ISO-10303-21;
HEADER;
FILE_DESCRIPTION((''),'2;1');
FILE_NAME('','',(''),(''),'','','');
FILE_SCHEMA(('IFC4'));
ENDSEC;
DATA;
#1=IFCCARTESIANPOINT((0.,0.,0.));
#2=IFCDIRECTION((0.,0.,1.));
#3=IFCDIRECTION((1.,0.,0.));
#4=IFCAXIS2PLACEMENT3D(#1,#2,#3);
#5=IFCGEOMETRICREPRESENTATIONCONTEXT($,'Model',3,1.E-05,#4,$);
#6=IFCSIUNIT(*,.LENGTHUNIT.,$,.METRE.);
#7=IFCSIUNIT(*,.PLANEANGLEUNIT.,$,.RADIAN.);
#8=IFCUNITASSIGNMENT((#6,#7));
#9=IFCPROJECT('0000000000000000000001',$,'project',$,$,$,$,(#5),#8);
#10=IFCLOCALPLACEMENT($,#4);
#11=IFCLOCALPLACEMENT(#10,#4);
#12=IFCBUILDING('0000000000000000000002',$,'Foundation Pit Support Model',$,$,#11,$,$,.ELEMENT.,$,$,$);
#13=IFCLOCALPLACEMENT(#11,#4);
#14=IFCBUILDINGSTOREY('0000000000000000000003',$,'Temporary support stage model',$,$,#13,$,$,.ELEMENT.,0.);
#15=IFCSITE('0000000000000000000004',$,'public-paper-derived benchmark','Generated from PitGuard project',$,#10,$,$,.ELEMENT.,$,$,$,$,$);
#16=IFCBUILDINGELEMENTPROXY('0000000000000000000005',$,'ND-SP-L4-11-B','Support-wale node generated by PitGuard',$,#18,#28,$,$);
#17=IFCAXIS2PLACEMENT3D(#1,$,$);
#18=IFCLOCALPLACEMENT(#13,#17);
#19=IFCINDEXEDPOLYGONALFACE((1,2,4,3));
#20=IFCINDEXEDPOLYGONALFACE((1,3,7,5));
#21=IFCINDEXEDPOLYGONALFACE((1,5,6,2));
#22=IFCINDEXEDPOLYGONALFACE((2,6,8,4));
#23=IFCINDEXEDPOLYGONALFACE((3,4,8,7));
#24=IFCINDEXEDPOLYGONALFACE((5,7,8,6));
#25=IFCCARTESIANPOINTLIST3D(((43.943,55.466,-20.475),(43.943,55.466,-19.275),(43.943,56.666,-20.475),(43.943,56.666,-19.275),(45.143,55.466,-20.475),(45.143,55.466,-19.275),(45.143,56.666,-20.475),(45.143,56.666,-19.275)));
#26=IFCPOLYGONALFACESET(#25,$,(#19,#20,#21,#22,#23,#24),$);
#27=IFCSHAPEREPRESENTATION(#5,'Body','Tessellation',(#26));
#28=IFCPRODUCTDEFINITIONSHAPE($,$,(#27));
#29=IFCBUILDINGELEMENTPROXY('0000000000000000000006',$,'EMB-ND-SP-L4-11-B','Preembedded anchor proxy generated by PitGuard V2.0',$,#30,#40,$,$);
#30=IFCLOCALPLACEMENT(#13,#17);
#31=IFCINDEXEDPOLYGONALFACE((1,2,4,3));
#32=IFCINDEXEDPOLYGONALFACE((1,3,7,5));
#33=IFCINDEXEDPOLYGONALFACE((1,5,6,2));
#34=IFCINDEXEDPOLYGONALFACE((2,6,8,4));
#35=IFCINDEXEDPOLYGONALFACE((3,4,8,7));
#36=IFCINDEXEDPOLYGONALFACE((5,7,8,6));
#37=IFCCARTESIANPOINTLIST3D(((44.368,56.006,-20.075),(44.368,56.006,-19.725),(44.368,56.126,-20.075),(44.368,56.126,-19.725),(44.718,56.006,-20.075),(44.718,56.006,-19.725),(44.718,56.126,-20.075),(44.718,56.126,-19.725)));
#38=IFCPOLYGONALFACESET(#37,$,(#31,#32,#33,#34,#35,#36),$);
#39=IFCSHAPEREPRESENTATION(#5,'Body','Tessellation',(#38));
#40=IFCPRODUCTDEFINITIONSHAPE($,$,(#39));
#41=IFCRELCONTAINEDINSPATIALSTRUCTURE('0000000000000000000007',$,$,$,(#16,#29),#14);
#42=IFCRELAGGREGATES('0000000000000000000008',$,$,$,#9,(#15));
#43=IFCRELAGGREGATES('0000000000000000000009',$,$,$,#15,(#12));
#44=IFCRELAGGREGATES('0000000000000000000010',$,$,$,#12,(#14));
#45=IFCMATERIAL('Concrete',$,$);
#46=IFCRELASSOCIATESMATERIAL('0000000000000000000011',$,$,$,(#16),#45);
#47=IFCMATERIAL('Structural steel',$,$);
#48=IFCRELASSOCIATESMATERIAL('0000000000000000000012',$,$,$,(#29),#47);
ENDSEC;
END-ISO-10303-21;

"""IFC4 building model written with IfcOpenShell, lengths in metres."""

from ifc_helpers import new_model, si_unit, frame, origin_with_axes, origin_2d, place, context, project, spatial, rectangle, extrude, material, element, save


model = new_model("IFC4")

# Units and contexts
model_context = context("Model", 3, precision=1e-05, world=origin_with_axes())
ifc_project = project(units=[si_unit("LENGTHUNIT", "METRE"), si_unit("PLANEANGLEUNIT", "RADIAN")], contexts=[model_context])

# Site, building, storey
site_placement = place(None, origin_with_axes())
site = spatial("IfcSite", under=ifc_project, at=site_placement, Name="public-paper-derived benchmark", Description="Generated from PitGuard project", CompositionType="ELEMENT")
building_placement = place(site_placement, origin_with_axes())
building = spatial("IfcBuilding", under=site, at=building_placement, Name="Foundation Pit Support Model", CompositionType="ELEMENT")
storey_placement = place(building_placement, origin_with_axes())
storey = spatial("IfcBuildingStorey", under=building, at=storey_placement, Name="Temporary support stage model", CompositionType="ELEMENT", Elevation=0.0)

# Shared definitions
ifc_material_1 = material(Name="Concrete")

# Shared definitions
ifc_material_2 = material(Name="Structural steel")

# Building element proxies
proxy_1_placement = place(storey_placement, frame((44.543, 56.066, -20.475), z_axis=(0.0, 0.0, 1.0), x_axis=(1.0, 0.0, 0.0)))
element("IfcBuildingElementProxy", 1, at=proxy_1_placement, inside=storey, material=ifc_material_1, Name="ND-SP-L4-11-B", Description="Support-wale node generated by PitGuard", context=model_context, shape_type="SweptSolid", body=[
    extrude(rectangle(XDim=1.2, YDim=1.2, at=origin_2d()), origin_with_axes(), (0.0, 0.0, 1.0), 1.2),
])
proxy_2_placement = place(storey_placement, frame((44.543, 56.066, -20.075), z_axis=(0.0, 0.0, 1.0), x_axis=(1.0, 0.0, 0.0)))
element("IfcBuildingElementProxy", 2, at=proxy_2_placement, inside=storey, material=ifc_material_2, Name="EMB-ND-SP-L4-11-B", Description="Preembedded anchor proxy generated by PitGuard V2.0", context=model_context, shape_type="SweptSolid", body=[
    extrude(rectangle(XDim=0.35, YDim=0.12, at=origin_2d()), origin_with_axes(), (0.0, 0.0, 1.0), 0.35),
])

save(model, "model.ifc")
